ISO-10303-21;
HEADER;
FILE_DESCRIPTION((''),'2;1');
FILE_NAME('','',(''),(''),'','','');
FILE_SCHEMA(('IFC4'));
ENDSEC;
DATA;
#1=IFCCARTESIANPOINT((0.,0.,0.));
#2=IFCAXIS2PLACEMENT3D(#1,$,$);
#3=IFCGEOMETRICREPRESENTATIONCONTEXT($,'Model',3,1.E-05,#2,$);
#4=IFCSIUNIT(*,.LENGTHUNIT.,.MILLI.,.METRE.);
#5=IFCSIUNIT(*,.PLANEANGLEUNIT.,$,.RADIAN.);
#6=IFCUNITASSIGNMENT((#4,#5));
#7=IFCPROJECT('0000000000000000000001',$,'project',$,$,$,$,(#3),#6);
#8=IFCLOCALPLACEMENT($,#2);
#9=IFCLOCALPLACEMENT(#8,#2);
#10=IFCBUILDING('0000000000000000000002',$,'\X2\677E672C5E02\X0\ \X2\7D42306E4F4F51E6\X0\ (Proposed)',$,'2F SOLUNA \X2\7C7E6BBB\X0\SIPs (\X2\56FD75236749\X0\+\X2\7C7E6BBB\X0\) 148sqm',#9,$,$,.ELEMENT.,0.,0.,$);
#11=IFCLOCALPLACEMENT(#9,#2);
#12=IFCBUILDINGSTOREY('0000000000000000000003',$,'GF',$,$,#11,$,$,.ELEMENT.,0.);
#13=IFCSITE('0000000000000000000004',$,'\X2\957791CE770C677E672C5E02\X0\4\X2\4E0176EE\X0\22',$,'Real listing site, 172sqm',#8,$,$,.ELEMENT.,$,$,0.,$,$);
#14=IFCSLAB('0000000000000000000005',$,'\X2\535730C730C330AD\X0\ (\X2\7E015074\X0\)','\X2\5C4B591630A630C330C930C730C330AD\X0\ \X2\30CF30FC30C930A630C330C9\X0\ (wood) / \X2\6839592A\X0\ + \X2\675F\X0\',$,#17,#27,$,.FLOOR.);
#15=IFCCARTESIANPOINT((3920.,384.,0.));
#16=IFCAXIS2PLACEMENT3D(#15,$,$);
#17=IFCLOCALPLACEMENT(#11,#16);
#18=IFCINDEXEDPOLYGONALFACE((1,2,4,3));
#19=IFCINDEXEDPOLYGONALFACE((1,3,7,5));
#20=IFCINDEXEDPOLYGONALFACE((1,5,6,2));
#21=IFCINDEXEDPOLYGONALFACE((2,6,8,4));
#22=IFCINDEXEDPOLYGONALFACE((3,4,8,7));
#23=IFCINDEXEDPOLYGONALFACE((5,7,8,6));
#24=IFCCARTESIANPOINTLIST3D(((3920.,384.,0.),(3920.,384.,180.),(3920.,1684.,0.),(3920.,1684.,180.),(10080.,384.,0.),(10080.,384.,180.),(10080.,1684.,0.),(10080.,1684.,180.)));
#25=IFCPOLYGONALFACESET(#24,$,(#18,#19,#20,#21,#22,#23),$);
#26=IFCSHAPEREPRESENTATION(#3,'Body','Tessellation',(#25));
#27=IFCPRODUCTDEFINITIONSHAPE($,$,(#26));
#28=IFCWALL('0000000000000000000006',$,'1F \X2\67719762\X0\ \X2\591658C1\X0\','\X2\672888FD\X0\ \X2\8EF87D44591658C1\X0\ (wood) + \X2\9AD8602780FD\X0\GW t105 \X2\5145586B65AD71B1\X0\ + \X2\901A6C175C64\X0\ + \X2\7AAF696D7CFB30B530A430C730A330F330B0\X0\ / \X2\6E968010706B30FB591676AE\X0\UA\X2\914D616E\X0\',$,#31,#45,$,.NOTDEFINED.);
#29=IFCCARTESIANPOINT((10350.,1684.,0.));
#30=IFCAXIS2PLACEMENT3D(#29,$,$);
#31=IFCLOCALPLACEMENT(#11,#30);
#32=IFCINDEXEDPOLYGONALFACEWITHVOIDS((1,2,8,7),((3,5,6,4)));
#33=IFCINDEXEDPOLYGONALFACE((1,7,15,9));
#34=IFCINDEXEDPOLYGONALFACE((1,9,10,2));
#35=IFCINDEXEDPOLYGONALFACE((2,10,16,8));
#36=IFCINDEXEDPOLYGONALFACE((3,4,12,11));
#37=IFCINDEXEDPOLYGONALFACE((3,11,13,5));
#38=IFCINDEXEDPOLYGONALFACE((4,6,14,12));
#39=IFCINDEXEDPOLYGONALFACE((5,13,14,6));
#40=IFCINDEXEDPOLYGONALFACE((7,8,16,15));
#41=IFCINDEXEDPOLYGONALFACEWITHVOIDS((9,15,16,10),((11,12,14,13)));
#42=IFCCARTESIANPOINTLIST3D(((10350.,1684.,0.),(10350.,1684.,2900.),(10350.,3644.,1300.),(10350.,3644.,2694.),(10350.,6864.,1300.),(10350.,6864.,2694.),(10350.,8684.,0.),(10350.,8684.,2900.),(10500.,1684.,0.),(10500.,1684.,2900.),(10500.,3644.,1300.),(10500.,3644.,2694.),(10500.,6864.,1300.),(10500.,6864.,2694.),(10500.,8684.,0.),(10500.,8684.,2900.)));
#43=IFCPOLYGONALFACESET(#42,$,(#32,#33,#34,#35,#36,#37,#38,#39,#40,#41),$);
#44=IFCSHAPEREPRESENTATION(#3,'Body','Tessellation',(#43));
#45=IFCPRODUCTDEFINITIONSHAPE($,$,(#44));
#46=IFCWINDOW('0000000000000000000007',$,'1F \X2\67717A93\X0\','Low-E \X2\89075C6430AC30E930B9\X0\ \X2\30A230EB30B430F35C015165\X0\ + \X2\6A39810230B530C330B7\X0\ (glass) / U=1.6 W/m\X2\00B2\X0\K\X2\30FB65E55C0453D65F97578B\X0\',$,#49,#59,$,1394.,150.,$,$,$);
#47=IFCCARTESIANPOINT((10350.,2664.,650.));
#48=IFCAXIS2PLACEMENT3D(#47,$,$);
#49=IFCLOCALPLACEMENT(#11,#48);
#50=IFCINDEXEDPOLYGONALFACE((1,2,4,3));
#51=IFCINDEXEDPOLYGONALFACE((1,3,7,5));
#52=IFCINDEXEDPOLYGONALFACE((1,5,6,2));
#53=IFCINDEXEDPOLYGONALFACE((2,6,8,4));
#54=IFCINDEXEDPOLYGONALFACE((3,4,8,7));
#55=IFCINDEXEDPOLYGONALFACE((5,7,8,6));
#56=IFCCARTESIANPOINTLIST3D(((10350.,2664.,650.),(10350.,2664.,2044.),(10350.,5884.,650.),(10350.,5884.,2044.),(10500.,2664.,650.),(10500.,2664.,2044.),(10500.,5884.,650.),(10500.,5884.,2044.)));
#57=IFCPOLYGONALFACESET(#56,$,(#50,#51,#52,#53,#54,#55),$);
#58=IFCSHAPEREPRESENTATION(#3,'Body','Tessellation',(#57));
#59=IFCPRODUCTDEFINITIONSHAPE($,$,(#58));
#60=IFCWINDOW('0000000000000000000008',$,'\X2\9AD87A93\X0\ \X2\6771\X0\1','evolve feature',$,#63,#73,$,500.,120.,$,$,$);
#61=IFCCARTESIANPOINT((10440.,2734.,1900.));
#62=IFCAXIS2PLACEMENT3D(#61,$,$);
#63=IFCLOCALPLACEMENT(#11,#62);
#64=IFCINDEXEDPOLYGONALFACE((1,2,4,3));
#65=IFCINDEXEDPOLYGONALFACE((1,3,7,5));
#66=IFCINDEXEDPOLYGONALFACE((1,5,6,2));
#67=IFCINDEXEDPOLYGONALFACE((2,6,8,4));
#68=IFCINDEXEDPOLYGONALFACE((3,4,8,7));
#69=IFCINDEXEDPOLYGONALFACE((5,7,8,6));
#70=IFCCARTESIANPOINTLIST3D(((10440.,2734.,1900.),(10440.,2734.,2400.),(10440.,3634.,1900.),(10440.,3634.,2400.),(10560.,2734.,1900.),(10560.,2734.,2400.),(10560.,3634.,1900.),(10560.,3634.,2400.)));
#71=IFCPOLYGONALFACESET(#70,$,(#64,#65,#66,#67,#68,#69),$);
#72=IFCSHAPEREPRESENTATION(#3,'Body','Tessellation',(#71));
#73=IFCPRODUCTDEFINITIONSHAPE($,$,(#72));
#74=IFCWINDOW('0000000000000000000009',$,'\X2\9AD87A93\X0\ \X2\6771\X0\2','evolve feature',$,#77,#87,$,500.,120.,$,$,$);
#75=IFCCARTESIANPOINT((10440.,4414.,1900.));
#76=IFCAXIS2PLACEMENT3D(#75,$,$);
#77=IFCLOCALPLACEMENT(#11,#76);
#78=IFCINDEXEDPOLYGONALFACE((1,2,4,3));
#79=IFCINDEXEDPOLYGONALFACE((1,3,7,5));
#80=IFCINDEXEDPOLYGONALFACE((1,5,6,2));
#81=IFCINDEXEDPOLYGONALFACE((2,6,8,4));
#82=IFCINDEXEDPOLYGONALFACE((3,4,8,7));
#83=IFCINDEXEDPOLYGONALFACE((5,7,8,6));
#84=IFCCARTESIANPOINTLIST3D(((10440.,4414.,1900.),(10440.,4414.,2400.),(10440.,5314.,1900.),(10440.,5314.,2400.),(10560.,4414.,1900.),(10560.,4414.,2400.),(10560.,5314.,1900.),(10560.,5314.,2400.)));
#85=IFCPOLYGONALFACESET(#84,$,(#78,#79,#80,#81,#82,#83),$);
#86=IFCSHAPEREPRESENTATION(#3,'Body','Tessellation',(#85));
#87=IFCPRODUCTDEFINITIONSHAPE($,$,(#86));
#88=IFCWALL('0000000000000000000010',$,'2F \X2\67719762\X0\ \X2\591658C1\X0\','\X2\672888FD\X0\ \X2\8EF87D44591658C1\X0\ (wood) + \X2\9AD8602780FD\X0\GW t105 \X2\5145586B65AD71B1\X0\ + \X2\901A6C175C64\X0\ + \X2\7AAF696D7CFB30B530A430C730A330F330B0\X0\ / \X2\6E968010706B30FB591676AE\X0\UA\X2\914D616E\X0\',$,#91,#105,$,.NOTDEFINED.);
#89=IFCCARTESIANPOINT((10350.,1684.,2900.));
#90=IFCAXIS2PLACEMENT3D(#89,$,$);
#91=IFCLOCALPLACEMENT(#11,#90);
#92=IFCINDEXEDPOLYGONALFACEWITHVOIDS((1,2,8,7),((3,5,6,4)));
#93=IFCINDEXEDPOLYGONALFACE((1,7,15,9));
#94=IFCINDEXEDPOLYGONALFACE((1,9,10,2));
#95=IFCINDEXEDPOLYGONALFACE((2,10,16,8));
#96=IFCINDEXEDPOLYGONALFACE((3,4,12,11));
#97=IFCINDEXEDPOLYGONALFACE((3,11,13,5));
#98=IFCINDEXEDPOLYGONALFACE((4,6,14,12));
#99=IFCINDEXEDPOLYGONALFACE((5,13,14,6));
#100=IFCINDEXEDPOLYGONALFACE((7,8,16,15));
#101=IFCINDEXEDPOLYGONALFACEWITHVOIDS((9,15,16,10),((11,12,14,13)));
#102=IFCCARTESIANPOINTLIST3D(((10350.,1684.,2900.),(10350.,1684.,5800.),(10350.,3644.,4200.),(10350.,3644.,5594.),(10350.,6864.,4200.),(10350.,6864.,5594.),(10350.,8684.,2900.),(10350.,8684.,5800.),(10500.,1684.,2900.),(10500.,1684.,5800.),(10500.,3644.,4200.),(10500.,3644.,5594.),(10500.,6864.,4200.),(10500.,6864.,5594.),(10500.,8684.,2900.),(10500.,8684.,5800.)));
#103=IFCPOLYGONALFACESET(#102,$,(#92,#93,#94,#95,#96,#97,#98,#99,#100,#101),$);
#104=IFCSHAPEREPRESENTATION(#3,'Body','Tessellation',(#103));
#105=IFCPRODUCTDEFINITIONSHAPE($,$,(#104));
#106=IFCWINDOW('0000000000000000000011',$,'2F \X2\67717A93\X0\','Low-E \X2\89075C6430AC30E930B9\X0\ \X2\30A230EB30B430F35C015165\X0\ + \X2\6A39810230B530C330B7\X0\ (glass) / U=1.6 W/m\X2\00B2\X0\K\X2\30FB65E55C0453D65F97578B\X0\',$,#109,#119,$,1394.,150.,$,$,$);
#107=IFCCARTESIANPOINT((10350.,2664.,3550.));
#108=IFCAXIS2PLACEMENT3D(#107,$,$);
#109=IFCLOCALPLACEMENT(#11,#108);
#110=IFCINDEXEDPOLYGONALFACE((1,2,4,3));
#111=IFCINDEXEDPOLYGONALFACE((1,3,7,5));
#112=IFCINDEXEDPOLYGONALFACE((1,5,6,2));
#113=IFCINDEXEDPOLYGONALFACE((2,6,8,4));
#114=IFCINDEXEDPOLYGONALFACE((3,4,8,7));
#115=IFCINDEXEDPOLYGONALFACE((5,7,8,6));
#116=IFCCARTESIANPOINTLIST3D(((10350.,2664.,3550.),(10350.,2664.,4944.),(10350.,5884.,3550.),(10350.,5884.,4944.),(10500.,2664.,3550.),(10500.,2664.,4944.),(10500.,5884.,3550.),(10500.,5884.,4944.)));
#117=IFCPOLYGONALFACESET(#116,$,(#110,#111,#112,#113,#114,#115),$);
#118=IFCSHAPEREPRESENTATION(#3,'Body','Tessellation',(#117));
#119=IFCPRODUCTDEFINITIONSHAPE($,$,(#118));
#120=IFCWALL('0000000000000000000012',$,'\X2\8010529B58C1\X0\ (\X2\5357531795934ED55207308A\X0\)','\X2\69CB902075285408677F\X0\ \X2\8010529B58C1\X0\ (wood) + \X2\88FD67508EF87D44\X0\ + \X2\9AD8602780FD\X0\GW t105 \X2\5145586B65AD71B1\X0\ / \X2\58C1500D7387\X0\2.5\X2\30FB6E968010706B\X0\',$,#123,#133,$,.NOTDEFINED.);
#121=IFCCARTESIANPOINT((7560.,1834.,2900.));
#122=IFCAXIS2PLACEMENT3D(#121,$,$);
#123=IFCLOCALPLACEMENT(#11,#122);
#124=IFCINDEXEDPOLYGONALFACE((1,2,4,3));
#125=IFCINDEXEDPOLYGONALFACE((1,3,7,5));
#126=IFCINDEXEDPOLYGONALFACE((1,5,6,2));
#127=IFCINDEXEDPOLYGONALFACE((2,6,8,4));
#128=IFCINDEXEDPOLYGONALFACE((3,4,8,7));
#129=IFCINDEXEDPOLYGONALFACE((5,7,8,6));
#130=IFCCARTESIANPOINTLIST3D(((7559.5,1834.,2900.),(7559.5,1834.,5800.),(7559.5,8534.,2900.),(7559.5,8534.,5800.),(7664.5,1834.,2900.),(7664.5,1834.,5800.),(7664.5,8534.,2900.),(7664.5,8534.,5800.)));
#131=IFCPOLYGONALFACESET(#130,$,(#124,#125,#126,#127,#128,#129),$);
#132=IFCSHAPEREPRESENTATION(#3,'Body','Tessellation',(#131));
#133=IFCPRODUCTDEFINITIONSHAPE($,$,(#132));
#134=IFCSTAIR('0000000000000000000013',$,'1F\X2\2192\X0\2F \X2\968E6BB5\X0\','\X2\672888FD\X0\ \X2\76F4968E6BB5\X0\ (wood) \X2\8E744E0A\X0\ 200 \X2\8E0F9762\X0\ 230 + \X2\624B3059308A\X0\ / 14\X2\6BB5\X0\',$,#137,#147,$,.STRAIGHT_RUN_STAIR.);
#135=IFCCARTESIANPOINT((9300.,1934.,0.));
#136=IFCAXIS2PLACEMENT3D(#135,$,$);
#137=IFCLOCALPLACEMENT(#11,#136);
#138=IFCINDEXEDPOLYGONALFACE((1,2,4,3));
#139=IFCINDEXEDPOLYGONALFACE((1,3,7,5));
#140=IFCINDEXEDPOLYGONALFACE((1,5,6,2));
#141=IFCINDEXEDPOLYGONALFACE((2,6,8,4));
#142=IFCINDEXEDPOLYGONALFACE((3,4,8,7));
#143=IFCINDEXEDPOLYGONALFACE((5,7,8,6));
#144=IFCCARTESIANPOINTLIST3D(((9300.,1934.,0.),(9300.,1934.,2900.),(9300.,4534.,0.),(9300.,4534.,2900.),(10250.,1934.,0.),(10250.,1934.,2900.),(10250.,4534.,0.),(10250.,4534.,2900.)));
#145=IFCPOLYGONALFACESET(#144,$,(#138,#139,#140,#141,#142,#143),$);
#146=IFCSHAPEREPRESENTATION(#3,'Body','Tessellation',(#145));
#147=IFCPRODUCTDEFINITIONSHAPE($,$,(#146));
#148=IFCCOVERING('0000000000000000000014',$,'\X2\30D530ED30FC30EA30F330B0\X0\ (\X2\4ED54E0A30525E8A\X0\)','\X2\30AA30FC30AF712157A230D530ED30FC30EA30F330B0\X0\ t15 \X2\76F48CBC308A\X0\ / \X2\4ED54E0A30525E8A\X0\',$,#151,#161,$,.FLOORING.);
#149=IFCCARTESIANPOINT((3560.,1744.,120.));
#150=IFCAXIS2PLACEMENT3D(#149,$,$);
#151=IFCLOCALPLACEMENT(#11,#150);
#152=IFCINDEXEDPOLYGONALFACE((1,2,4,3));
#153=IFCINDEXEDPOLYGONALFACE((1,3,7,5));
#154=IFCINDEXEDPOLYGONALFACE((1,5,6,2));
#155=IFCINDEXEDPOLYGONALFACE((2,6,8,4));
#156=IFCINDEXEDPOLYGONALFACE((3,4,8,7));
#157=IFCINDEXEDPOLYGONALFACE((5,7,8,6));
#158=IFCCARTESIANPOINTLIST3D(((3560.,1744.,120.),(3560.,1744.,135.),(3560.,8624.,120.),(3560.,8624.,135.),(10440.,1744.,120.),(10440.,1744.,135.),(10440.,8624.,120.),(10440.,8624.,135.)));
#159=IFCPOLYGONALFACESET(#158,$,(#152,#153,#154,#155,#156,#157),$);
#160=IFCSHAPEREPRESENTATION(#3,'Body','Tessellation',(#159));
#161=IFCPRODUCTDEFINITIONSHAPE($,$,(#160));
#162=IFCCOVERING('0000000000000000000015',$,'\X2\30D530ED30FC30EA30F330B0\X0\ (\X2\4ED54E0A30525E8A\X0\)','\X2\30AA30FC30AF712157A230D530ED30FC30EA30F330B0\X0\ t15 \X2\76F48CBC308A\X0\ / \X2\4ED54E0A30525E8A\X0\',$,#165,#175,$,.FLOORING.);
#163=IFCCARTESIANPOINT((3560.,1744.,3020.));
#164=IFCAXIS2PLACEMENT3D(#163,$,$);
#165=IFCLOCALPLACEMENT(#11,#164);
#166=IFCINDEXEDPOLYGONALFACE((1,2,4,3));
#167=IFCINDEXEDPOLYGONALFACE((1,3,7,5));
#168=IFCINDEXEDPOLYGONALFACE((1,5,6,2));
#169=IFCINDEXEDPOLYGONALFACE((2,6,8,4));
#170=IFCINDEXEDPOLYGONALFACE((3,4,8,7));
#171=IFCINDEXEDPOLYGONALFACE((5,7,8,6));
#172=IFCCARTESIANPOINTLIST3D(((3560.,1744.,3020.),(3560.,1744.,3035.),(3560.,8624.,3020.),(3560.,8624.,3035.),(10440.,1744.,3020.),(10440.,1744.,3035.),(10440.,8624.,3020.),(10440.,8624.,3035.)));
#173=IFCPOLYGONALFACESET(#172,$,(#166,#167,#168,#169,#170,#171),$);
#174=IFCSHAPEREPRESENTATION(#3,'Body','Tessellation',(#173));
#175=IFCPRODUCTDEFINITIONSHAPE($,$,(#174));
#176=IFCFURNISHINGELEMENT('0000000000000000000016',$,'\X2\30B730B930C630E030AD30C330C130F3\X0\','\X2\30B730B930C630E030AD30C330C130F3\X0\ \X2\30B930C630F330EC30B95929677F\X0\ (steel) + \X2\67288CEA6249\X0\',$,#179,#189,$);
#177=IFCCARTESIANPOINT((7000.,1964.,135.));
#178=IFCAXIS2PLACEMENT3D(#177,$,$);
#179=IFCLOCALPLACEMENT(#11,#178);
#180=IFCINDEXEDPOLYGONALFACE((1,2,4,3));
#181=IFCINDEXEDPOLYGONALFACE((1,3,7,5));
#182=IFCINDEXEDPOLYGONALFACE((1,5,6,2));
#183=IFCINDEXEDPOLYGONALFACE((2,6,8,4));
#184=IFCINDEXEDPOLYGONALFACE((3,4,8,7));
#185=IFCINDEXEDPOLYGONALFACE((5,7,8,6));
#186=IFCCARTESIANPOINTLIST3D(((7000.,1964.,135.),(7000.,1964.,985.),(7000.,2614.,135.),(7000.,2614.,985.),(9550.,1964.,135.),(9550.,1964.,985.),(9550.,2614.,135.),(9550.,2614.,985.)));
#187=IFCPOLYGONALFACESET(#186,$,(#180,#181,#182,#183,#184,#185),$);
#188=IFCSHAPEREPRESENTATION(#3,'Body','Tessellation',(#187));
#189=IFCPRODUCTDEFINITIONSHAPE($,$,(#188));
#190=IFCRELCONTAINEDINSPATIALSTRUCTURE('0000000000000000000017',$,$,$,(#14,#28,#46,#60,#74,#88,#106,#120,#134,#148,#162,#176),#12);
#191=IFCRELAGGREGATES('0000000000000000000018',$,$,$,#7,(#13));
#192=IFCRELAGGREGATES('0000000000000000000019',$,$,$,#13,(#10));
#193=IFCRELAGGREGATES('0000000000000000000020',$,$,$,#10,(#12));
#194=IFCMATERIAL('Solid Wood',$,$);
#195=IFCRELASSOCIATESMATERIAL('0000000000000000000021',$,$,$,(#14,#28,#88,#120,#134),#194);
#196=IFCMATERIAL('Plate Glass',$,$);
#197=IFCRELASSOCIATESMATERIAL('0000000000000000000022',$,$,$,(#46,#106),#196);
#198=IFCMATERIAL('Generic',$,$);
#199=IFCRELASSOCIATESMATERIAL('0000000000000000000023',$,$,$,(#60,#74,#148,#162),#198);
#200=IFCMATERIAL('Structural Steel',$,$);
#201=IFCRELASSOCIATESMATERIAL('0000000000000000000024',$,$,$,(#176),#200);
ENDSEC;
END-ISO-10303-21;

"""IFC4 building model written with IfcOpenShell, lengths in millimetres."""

from ifc_helpers import new_model, si_unit, frame, frame_2d, origin, place, context, project, spatial, rectangle, extrude, material, element, fill, save


model = new_model("IFC4")

# Units and contexts
model_context = context("Model", 3, precision=1e-05, world=origin())
ifc_project = project(units=[si_unit("LENGTHUNIT", "METRE", prefix="MILLI"), si_unit("PLANEANGLEUNIT", "RADIAN")], contexts=[model_context])

# Site, building, storey
site_placement = place(None, origin())
site = spatial("IfcSite", under=ifc_project, at=site_placement, Name="長野県松本市4丁目22", ObjectType="Real listing site, 172sqm", CompositionType="ELEMENT", RefElevation=0.0)
building_placement = place(site_placement, origin())
building = spatial("IfcBuilding", under=site, at=building_placement, Name="松本市 終の住処 (Proposed)", ObjectType="2F SOLUNA 籾殻SIPs (国産杉+籾殻) 148sqm", CompositionType="ELEMENT", ElevationOfRefHeight=0.0, ElevationOfTerrain=0.0)
storey_placement = place(building_placement, origin())
storey = spatial("IfcBuildingStorey", under=building, at=storey_placement, Name="GF", CompositionType="ELEMENT", Elevation=0.0)

# Slab
ifc_material_1 = material(Name="Solid Wood")
slab_placement = place(storey_placement, frame((3920.0, 384.0, 0.0)))
element("IfcSlab", 1, at=slab_placement, inside=storey, material=ifc_material_1, Name="南デッキ (縁側)", Description="屋外ウッドデッキ ハードウッド (wood) / 根太 + 束", PredefinedType="FLOOR", context=model_context, shape_type="SweptSolid", body=[
    extrude(rectangle(XDim=6160.0, YDim=1300.0, at=frame_2d((3080.0, 650.0))), frame((3920.0, 384.0, 0.0)), (0.0, 0.0, 1.0), 180.0),
])

# Wall, openings, windows
wall_1_placement = place(storey_placement, frame((10350.0, 1684.0, 0.0)))
wall_1 = element("IfcWall", 2, at=wall_1_placement, inside=storey, material=ifc_material_1, Name="1F 東面 外壁", Description="木製 軸組外壁 (wood) + 高性能GW t105 充填断熱 + 通気層 + 窯業系サイディング / 準耐火・外皮UA配慮", PredefinedType="NOTDEFINED", context=model_context, shape_type="SweptSolid", body=[
    extrude(rectangle(XDim=150.0, YDim=7000.0, at=frame_2d((75.0, 3500.0))), frame((10350.0, 1684.0, 0.0)), (0.0, 0.0, 1.0), 2900.0),
])
opening_1_placement = place(storey_placement, frame((10350.0, 2664.0, 650.0)))
opening_1 = element("IfcOpeningElement", 3, at=opening_1_placement, cuts=wall_1, PredefinedType="NOTDEFINED", context=model_context, shape_type="SweptSolid", body=[
    extrude(rectangle(XDim=150.0, YDim=3220.0, at=frame_2d((75.0, 1610.0))), frame((10350.0, 2664.0, 650.0)), (0.0, 0.0, 1.0), 1394.0),
])
opening_2_placement = place(storey_placement, frame((10440.0, 2734.0, 1900.0)))
opening_2 = element("IfcOpeningElement", 4, at=opening_2_placement, cuts=wall_1, PredefinedType="NOTDEFINED", context=model_context, shape_type="SweptSolid", body=[
    extrude(rectangle(XDim=120.0, YDim=900.0, at=frame_2d((60.0, 450.0))), frame((10440.0, 2734.0, 1900.0)), (0.0, 0.0, 1.0), 500.0),
])
opening_3_placement = place(storey_placement, frame((10440.0, 4414.0, 1900.0)))
opening_3 = element("IfcOpeningElement", 5, at=opening_3_placement, cuts=wall_1, PredefinedType="NOTDEFINED", context=model_context, shape_type="SweptSolid", body=[
    extrude(rectangle(XDim=120.0, YDim=900.0, at=frame_2d((60.0, 450.0))), frame((10440.0, 4414.0, 1900.0)), (0.0, 0.0, 1.0), 500.0),
])
ifc_material_2 = material(Name="Plate Glass")
window_1_placement = place(storey_placement, frame((10350.0, 2664.0, 650.0)))
window_1 = element("IfcWindow", 6, at=window_1_placement, inside=storey, material=ifc_material_2, Name="1F 東窓", Description="Low-E 複層ガラス アルゴン封入 + 樹脂サッシ (glass) / U=1.6 W/m²K・日射取得型", OverallHeight=1394.0, OverallWidth=150.0, context=model_context, shape_type="SweptSolid", body=[
    extrude(rectangle(XDim=150.0, YDim=3220.0, at=frame_2d((75.0, 1610.0))), frame((10350.0, 2664.0, 650.0)), (0.0, 0.0, 1.0), 1394.0),
])
fill(opening_1, window_1)
ifc_material_3 = material(Name="Generic")
window_2_placement = place(storey_placement, frame((10440.0, 2734.0, 1900.0)))
window_2 = element("IfcWindow", 7, at=window_2_placement, inside=storey, material=ifc_material_3, Name="高窓 東1", Description="evolve feature", OverallHeight=500.0, OverallWidth=120.0, context=model_context, shape_type="SweptSolid", body=[
    extrude(rectangle(XDim=120.0, YDim=900.0, at=frame_2d((60.0, 450.0))), frame((10440.0, 2734.0, 1900.0)), (0.0, 0.0, 1.0), 500.0),
])
fill(opening_2, window_2)
window_3_placement = place(storey_placement, frame((10440.0, 4414.0, 1900.0)))
window_3 = element("IfcWindow", 8, at=window_3_placement, inside=storey, material=ifc_material_3, Name="高窓 東2", Description="evolve feature", OverallHeight=500.0, OverallWidth=120.0, context=model_context, shape_type="SweptSolid", body=[
    extrude(rectangle(XDim=120.0, YDim=900.0, at=frame_2d((60.0, 450.0))), frame((10440.0, 4414.0, 1900.0)), (0.0, 0.0, 1.0), 500.0),
])
fill(opening_3, window_3)

# Wall, opening, window
wall_2_placement = place(storey_placement, frame((10350.0, 1684.0, 2900.0)))
wall_2 = element("IfcWall", 9, at=wall_2_placement, inside=storey, material=ifc_material_1, Name="2F 東面 外壁", Description="木製 軸組外壁 (wood) + 高性能GW t105 充填断熱 + 通気層 + 窯業系サイディング / 準耐火・外皮UA配慮", PredefinedType="NOTDEFINED", context=model_context, shape_type="SweptSolid", body=[
    extrude(rectangle(XDim=150.0, YDim=7000.0, at=frame_2d((75.0, 3500.0))), frame((10350.0, 1684.0, 2900.0)), (0.0, 0.0, 1.0), 2900.0),
])
opening_4_placement = place(storey_placement, frame((10350.0, 2664.0, 3550.0)))
opening_4 = element("IfcOpeningElement", 10, at=opening_4_placement, cuts=wall_2, PredefinedType="NOTDEFINED", context=model_context, shape_type="SweptSolid", body=[
    extrude(rectangle(XDim=150.0, YDim=3220.0, at=frame_2d((75.0, 1610.0))), frame((10350.0, 2664.0, 3550.0)), (0.0, 0.0, 1.0), 1394.0),
])
window_4_placement = place(storey_placement, frame((10350.0, 2664.0, 3550.0)))
window_4 = element("IfcWindow", 11, at=window_4_placement, inside=storey, material=ifc_material_2, Name="2F 東窓", Description="Low-E 複層ガラス アルゴン封入 + 樹脂サッシ (glass) / U=1.6 W/m²K・日射取得型", OverallHeight=1394.0, OverallWidth=150.0, context=model_context, shape_type="SweptSolid", body=[
    extrude(rectangle(XDim=150.0, YDim=3220.0, at=frame_2d((75.0, 1610.0))), frame((10350.0, 2664.0, 3550.0)), (0.0, 0.0, 1.0), 1394.0),
])
fill(opening_4, window_4)

# Wall
wall_3_placement = place(storey_placement, frame((7560.0, 1834.0, 2900.0)))
element("IfcWall", 12, at=wall_3_placement, inside=storey, material=ifc_material_1, Name="耐力壁 (南北間仕切り)", Description="構造用合板 耐力壁 (wood) + 製材軸組 + 高性能GW t105 充填断熱 / 壁倍率2.5・準耐火", PredefinedType="NOTDEFINED", context=model_context, shape_type="SweptSolid", body=[
    extrude(rectangle(XDim=105.0, YDim=6700.0, at=frame_2d((52.0, 3350.0))), frame((7560.0, 1834.0, 2900.0)), (0.0, 0.0, 1.0), 2900.0),
])

# Stair
stair_placement = place(storey_placement, frame((9300.0, 1934.0, 0.0)))
element("IfcStair", 13, at=stair_placement, inside=storey, material=ifc_material_1, Name="1F→2F 階段", Description="木製 直階段 (wood) 蹴上 200 踏面 230 + 手すり / 14段", PredefinedType="STRAIGHT_RUN_STAIR", context=model_context, shape_type="SweptSolid", body=[
    extrude(rectangle(XDim=950.0, YDim=2600.0, at=frame_2d((475.0, 1300.0))), frame((9300.0, 1934.0, 0.0)), (0.0, 0.0, 1.0), 2900.0),
])

# Coverings
covering_1_placement = place(storey_placement, frame((3560.0, 1744.0, 120.0)))
element("IfcCovering", 14, at=covering_1_placement, inside=storey, material=ifc_material_3, Name="フローリング (仕上げ床)", Description="オーク無垢フローリング t15 直貼り / 仕上げ床", PredefinedType="FLOORING", context=model_context, shape_type="SweptSolid", body=[
    extrude(rectangle(XDim=6880.0, YDim=6880.0, at=frame_2d((3440.0, 3440.0))), frame((3560.0, 1744.0, 120.0)), (0.0, 0.0, 1.0), 15.0),
])
covering_2_placement = place(storey_placement, frame((3560.0, 1744.0, 3020.0)))
element("IfcCovering", 15, at=covering_2_placement, inside=storey, material=ifc_material_3, Name="フローリング (仕上げ床)", Description="オーク無垢フローリング t15 直貼り / 仕上げ床", PredefinedType="FLOORING", context=model_context, shape_type="SweptSolid", body=[
    extrude(rectangle(XDim=6880.0, YDim=6880.0, at=frame_2d((3440.0, 3440.0))), frame((3560.0, 1744.0, 3020.0)), (0.0, 0.0, 1.0), 15.0),
])

# Furnishing element
ifc_material_4 = material(Name="Structural Steel")
furnishing_1_placement = place(storey_placement, frame((7000.0, 1964.0, 135.0)))
element("IfcFurnishingElement", 16, at=furnishing_1_placement, inside=storey, material=ifc_material_4, Name="システムキッチン", Description="システムキッチン ステンレス天板 (steel) + 木質扉", context=model_context, shape_type="SweptSolid", body=[
    extrude(rectangle(XDim=2550.0, YDim=650.0, at=frame_2d((1275.0, 325.0))), frame((7000.0, 1964.0, 135.0)), (0.0, 0.0, 1.0), 850.0),
])

save(model, "model.ifc")
